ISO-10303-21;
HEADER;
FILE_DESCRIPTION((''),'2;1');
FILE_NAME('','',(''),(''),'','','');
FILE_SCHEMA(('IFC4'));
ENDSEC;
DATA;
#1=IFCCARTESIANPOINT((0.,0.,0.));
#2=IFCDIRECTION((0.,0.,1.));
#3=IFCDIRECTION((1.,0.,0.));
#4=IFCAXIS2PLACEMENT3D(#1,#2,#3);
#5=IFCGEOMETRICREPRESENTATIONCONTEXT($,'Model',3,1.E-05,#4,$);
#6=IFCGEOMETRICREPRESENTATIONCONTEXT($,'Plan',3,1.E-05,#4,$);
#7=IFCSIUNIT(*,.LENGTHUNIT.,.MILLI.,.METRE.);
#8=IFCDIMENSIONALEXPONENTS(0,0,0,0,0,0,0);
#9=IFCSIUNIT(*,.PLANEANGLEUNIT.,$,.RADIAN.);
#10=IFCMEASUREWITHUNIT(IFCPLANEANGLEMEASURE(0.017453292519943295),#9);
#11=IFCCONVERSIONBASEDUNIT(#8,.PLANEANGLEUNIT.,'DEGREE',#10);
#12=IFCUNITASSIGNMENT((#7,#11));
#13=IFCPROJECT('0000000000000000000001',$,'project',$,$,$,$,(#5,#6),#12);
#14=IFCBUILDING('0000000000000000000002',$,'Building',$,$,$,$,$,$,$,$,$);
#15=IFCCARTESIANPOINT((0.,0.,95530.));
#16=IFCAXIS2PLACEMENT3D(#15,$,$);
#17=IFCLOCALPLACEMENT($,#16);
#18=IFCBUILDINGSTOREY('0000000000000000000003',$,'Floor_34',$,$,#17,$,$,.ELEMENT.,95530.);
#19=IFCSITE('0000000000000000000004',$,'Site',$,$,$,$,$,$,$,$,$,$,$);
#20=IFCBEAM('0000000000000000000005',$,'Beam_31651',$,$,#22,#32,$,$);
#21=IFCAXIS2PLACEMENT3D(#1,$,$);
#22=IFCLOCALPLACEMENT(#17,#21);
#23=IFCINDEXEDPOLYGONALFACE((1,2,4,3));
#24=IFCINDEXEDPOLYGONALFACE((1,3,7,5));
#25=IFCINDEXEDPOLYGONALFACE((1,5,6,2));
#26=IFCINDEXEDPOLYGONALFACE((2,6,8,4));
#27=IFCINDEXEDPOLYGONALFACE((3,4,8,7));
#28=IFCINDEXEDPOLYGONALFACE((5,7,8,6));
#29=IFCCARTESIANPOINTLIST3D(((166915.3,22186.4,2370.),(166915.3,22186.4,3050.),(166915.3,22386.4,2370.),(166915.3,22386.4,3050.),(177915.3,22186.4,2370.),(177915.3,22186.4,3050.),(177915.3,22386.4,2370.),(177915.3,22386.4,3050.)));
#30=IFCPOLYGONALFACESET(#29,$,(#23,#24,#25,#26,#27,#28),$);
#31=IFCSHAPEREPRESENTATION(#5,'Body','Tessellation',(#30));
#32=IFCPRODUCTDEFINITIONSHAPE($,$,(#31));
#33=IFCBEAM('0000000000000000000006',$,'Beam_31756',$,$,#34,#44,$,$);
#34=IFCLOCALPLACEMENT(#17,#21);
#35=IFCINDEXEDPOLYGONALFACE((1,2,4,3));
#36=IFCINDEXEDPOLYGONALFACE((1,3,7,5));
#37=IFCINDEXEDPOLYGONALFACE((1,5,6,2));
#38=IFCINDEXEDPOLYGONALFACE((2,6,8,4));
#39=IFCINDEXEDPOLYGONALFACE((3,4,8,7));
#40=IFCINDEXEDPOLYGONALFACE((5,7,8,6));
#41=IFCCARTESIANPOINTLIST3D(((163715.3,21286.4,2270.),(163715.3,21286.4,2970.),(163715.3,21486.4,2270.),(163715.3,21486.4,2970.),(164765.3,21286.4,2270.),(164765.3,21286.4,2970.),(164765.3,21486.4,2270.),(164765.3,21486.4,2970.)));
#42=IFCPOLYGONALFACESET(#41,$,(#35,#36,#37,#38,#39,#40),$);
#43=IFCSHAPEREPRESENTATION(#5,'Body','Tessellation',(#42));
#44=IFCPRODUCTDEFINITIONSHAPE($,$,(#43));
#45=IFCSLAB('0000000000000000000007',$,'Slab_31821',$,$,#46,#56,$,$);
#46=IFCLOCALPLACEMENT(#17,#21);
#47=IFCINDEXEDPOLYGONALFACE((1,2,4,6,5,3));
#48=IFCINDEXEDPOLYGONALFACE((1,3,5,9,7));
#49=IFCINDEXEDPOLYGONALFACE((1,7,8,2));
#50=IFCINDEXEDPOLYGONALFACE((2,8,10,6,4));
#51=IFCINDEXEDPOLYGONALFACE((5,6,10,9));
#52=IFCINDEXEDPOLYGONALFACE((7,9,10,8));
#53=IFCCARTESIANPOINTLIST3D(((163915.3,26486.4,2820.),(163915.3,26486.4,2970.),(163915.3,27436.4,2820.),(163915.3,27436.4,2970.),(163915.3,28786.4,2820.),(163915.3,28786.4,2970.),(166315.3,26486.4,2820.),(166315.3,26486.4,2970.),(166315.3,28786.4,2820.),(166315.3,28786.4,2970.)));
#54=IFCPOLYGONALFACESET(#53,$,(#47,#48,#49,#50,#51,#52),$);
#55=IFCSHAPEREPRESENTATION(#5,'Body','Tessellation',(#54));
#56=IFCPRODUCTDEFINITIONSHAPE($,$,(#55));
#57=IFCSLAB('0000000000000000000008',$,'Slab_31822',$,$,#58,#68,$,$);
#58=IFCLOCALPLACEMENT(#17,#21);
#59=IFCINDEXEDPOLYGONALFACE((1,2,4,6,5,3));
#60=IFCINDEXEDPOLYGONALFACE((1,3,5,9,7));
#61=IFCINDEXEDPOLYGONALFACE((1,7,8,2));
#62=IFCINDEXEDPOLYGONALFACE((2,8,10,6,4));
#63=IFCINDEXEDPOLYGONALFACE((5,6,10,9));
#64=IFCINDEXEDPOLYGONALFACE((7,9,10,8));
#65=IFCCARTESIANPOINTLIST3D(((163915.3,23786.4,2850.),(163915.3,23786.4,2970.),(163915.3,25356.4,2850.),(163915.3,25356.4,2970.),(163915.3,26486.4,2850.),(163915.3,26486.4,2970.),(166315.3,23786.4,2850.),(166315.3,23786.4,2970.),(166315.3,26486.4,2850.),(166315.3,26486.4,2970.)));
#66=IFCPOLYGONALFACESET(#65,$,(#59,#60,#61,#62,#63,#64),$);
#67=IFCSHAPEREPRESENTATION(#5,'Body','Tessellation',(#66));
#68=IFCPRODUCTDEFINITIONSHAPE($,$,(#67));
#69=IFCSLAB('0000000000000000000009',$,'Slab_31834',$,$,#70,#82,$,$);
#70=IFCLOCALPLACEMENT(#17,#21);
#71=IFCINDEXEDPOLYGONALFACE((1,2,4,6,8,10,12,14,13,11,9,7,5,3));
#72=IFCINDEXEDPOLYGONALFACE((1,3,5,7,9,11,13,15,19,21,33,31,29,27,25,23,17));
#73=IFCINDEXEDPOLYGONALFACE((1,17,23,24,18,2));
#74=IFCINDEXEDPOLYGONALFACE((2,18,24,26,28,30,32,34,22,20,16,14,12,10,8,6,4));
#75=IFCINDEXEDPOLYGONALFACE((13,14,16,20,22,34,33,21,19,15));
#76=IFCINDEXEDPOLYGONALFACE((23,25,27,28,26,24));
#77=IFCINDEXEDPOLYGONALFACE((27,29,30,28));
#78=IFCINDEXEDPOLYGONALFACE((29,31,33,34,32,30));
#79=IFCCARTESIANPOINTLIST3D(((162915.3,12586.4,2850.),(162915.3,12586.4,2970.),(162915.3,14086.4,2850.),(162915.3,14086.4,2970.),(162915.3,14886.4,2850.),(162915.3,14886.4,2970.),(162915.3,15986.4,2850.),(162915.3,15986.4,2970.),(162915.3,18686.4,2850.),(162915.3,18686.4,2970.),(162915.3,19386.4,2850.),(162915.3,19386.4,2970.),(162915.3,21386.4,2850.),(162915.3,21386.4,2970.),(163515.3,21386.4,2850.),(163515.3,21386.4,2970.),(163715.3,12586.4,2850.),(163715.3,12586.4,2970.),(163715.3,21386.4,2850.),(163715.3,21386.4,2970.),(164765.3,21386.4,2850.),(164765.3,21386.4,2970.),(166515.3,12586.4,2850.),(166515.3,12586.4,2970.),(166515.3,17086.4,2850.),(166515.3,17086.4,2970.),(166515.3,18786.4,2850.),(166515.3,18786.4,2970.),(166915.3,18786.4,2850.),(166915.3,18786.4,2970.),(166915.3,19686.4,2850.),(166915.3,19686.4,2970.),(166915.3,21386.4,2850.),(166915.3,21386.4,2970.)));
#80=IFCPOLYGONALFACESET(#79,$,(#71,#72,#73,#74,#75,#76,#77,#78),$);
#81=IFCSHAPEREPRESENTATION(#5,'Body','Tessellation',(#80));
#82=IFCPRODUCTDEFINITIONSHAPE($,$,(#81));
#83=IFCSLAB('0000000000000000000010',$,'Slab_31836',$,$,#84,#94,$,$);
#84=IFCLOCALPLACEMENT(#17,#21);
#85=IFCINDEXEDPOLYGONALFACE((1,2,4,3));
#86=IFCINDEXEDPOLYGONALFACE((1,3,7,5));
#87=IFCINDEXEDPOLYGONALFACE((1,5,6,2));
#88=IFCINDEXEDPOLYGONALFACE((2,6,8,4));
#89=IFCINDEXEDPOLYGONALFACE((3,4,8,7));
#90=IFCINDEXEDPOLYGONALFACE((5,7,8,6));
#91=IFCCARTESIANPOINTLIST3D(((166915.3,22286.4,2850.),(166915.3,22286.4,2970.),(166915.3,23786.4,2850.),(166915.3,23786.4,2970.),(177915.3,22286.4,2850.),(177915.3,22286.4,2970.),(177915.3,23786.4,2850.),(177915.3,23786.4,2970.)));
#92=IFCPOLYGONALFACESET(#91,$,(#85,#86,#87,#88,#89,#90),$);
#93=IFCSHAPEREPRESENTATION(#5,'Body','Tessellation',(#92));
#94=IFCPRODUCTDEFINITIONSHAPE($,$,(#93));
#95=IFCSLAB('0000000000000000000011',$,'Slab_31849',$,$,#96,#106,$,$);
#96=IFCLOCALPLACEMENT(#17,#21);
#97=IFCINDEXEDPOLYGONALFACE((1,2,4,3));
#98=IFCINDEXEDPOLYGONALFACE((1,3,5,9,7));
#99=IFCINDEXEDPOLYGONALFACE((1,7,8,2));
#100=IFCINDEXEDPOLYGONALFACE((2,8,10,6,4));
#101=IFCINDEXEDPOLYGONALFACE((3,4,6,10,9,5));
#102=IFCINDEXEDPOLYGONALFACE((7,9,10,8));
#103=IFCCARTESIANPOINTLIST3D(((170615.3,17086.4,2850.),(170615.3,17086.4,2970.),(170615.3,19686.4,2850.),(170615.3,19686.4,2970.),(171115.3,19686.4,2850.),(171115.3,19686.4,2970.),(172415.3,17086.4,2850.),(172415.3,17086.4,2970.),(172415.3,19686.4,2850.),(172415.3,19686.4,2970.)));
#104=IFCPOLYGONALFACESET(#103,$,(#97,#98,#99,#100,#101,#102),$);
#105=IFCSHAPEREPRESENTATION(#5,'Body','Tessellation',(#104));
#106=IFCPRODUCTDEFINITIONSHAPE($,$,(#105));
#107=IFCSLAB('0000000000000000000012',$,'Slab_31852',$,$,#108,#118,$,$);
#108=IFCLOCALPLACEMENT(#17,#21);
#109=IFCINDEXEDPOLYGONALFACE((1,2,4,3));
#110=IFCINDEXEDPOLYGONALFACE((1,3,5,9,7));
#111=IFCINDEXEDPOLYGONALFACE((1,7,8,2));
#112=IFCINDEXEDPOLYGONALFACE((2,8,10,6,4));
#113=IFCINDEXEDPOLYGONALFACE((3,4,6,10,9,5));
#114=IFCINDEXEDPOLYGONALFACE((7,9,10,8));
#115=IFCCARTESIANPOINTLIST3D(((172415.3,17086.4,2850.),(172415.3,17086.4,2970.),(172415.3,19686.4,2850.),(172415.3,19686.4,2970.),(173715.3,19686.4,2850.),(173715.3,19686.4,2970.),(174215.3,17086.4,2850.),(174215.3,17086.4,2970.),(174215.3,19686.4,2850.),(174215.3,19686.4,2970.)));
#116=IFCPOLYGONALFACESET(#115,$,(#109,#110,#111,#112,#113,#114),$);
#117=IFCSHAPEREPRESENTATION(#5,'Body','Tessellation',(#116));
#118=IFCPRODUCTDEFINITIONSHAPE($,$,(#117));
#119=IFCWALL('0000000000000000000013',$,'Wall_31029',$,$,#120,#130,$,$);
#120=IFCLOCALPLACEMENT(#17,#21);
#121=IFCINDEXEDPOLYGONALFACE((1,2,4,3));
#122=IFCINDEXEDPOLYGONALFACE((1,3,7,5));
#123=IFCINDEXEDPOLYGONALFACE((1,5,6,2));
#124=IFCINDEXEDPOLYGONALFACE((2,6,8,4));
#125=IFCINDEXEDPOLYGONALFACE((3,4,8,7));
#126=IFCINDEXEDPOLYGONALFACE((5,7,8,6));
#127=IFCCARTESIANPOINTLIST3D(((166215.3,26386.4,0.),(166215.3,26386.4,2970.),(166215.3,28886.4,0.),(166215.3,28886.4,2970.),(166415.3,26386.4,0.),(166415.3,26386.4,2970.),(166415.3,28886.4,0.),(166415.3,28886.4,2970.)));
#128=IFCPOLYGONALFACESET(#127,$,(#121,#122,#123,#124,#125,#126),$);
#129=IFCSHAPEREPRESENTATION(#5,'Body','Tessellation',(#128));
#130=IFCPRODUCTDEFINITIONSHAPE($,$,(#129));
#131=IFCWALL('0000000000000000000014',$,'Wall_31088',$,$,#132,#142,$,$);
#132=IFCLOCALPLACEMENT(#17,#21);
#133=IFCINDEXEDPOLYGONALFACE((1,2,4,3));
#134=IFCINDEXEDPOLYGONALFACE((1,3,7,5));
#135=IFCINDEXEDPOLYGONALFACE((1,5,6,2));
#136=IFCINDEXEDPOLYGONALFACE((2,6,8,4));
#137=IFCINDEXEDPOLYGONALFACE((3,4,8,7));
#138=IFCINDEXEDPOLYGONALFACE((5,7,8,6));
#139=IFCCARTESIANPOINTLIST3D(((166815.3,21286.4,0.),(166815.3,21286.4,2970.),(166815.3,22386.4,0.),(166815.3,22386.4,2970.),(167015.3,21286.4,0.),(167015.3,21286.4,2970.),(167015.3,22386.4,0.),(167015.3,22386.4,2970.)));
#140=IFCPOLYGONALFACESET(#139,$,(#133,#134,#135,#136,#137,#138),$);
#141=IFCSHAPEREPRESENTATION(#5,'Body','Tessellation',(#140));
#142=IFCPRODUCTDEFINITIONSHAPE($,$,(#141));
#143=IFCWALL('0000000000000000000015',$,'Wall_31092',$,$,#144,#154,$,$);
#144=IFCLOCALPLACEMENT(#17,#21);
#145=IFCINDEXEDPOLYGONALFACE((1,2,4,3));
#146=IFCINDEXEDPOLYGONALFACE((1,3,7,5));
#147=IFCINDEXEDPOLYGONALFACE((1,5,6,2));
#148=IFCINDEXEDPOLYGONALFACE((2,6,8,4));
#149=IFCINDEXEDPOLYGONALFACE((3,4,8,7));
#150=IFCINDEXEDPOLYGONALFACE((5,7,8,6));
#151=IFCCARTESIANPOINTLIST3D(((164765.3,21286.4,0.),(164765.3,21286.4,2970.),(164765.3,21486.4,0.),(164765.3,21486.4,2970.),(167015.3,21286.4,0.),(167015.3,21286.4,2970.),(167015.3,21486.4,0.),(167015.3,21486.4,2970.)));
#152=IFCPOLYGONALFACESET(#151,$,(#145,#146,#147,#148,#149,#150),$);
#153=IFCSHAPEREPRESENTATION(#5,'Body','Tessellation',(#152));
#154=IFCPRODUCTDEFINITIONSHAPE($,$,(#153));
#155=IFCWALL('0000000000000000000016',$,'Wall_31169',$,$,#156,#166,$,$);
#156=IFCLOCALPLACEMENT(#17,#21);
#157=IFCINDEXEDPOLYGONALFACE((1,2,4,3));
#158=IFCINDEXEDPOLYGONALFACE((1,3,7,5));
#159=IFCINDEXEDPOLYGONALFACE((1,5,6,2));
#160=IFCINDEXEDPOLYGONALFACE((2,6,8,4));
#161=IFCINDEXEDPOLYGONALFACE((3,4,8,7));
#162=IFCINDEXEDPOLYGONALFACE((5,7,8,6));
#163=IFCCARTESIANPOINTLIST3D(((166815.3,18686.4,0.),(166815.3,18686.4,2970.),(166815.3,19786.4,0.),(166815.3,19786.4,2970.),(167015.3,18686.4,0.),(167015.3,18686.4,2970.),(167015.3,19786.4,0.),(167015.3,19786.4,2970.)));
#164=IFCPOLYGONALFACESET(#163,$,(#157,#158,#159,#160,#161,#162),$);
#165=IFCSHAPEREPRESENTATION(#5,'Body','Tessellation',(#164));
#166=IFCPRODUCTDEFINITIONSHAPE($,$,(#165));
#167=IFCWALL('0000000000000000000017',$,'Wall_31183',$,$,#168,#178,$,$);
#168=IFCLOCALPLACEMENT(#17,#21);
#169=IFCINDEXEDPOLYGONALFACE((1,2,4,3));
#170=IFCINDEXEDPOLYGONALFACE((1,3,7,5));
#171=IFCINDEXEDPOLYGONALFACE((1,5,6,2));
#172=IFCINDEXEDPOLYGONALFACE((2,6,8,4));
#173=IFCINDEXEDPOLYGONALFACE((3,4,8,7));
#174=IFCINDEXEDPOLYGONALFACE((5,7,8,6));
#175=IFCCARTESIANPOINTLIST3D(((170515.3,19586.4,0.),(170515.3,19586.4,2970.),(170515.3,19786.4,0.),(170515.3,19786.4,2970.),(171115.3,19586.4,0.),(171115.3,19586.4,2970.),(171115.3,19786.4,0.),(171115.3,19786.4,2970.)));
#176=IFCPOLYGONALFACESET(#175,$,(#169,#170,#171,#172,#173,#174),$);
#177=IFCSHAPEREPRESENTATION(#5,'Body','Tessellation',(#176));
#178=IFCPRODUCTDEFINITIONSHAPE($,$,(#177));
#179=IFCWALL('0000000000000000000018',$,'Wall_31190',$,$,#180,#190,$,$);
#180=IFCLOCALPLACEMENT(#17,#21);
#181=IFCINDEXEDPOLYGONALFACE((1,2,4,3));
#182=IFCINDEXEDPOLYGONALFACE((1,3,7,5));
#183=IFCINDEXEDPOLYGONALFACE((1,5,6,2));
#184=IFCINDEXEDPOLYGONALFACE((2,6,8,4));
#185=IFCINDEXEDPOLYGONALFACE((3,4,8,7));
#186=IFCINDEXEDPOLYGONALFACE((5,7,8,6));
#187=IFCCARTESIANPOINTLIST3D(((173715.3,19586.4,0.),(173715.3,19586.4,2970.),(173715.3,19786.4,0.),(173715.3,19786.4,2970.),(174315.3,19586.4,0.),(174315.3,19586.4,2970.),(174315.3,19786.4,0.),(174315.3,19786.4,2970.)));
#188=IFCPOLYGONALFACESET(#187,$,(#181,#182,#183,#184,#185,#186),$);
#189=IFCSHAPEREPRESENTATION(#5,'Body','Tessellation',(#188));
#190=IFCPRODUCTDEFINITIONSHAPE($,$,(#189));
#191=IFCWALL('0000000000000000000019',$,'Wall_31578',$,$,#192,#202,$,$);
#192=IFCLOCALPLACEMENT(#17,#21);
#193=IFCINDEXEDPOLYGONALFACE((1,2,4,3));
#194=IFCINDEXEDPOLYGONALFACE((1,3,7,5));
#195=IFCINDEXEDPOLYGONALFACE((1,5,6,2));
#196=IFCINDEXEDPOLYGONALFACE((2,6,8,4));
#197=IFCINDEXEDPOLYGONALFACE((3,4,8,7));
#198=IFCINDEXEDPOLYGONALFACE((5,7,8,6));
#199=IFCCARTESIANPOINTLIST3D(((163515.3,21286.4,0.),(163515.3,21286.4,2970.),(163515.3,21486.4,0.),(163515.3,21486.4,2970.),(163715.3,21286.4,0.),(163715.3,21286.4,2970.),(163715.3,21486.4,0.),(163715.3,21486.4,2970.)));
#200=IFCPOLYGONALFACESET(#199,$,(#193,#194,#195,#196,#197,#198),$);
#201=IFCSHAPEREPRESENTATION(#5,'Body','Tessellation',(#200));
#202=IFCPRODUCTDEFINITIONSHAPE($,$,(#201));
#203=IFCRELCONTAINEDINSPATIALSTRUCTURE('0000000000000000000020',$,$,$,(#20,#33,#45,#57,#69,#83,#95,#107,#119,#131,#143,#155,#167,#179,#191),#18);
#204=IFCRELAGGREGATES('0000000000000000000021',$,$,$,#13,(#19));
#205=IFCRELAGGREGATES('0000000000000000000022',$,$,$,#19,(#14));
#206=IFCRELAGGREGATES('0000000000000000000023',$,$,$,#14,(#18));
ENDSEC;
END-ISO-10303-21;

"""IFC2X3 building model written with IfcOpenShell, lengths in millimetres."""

from ifc_helpers import new_model, entity, si_unit, converted_unit, frame, origin_with_axes, origin_2d, place, context, project, spatial, polyline, rectangle, outline, extrude, element, save


model = new_model("IFC2X3")

# Units and contexts
model_context = context("Model", 3, precision=1e-05, world=origin_with_axes())
plan_context = context("Plan", 3, precision=1e-05, world=origin_with_axes())
ifc_project = project(units=[si_unit("LENGTHUNIT", "METRE", prefix="MILLI"), converted_unit("PLANEANGLEUNIT", "DEGREE", entity("IfcPlaneAngleMeasure", 0.017453292519943295), si_unit("PLANEANGLEUNIT", "RADIAN"), dimensions=[0, 0, 0, 0, 0, 0, 0])], contexts=[model_context, plan_context])

# Site, building, storey
site = spatial("IfcSite", under=ifc_project, Name="Site")
building = spatial("IfcBuilding", under=site, Name="Building")
storey_placement = place(None, frame((0.0, 0.0, 95530.0)))
storey = spatial("IfcBuildingStorey", under=building, at=storey_placement, Name="Floor_34", CompositionType="ELEMENT", Elevation=95530.0)

# Beams
beam_1_placement = place(storey_placement, frame((166915.3, 22286.4, 2710.0), z_axis=(10999.999785, 0.0, 0.0), x_axis=(0.0, -10999.999785, 0.0)))
element("IfcBeam", 1, at=beam_1_placement, inside=storey, Name="Beam_31651", context=model_context, shape_type="SweptSolid", body=[
    extrude(rectangle(XDim=200.0, YDim=680.0, at=origin_2d()), origin_with_axes(), (0.0, 0.0, 1.0), 11000.0),
])
beam_2_placement = place(storey_placement, frame((163715.3, 21386.4, 2620.0), z_axis=(1050.0, 0.0, 0.0), x_axis=(0.0, -1050.0, 0.0)))
element("IfcBeam", 2, at=beam_2_placement, inside=storey, Name="Beam_31756", context=model_context, shape_type="SweptSolid", body=[
    extrude(rectangle(XDim=200.0, YDim=700.0, at=origin_2d()), origin_with_axes(), (0.0, 0.0, 1.0), 1050.0),
])

# Slabs
slab_1_placement = place(storey_placement, frame((163915.3, 28786.4, 2820.0), z_axis=(0.0, 0.0, 1.0), x_axis=(0.0, -1350.0, 0.0)))
element("IfcSlab", 3, at=slab_1_placement, inside=storey, Name="Slab_31821", context=model_context, shape_type="SweptSolid", body=[
    extrude(outline(polyline([(0.0, 0.0), (1350.0, 0.0), (2300.0, 0.0), (2300.0, 2400.0), (0.0, 2400.0)])), origin_with_axes(), (0.0, 0.0, 1.0), 150.0),
])
slab_2_placement = place(storey_placement, frame((163915.3, 26486.4, 2850.0), z_axis=(0.0, 0.0, 1.0), x_axis=(0.0, -1130.0, 0.0)))
element("IfcSlab", 4, at=slab_2_placement, inside=storey, Name="Slab_31822", context=model_context, shape_type="SweptSolid", body=[
    extrude(outline(polyline([(0.0, 0.0), (1130.0, 0.0), (2700.0, 0.0), (2700.0, 2400.0), (0.0, 2400.0)])), origin_with_axes(), (0.0, 0.0, 1.0), 120.0),
])
slab_3_placement = place(storey_placement, frame((164765.3, 21386.4, 2850.0), z_axis=(0.0, 0.0, 1.0), x_axis=(-1050.0, 0.0, 0.0)))
element("IfcSlab", 5, at=slab_3_placement, inside=storey, Name="Slab_31834", context=model_context, shape_type="SweptSolid", body=[
    extrude(outline(polyline([(0.0, 0.0), (1050.0, 0.0), (1250.0, 0.0), (1850.0, 0.0), (1850.0, 2000.0), (1850.0, 2700.0), (1850.0, 5400.0), (1850.0, 6500.0), (1850.0, 7300.0), (1850.0, 8800.0), (1050.0, 8800.0), (-1750.0, 8800.0), (-1750.0, 4300.0), (-1750.0, 2600.0), (-2150.0, 2600.0), (-2150.0, 1700.0), (-2150.0, 0.0)])), origin_with_axes(), (0.0, 0.0, 1.0), 120.0),
])
slab_4_placement = place(storey_placement, frame((166915.3, 23786.4, 2850.0), z_axis=(0.0, 0.0, 1.0), x_axis=(0.0, -1500.0, 0.0)))
element("IfcSlab", 6, at=slab_4_placement, inside=storey, Name="Slab_31836", context=model_context, shape_type="SweptSolid", body=[
    extrude(outline(polyline([(0.0, 0.0), (1500.0, 0.0), (1500.0, 11000.0), (0.0, 11000.0)])), origin_with_axes(), (0.0, 0.0, 1.0), 120.0),
])
slab_5_placement = place(storey_placement, frame((170615.3, 19686.4, 2850.0), z_axis=(0.0, 0.0, 1.0), x_axis=(0.0, -2599.99, 0.0)))
element("IfcSlab", 7, at=slab_5_placement, inside=storey, Name="Slab_31849", context=model_context, shape_type="SweptSolid", body=[
    extrude(outline(polyline([(0.0, 0.0), (2600.0, 0.0), (2600.0, 1800.0), (0.0, 1800.0), (0.0, 500.0)])), origin_with_axes(), (0.0, 0.0, 1.0), 120.0),
])
slab_6_placement = place(storey_placement, frame((172415.3, 19686.4, 2850.0), z_axis=(0.0, 0.0, 1.0), x_axis=(0.0, -2599.99, 0.0)))
element("IfcSlab", 8, at=slab_6_placement, inside=storey, Name="Slab_31852", context=model_context, shape_type="SweptSolid", body=[
    extrude(outline(polyline([(0.0, 0.0), (2600.0, 0.0), (2600.0, 1800.0), (0.0, 1800.0), (0.0, 1300.0)])), origin_with_axes(), (0.0, 0.0, 1.0), 120.0),
])

# Walls
wall_1_placement = place(storey_placement, frame((166315.3, 27636.4, 0.0), z_axis=(0.0, 0.0, 1.0), x_axis=(0.0, 2500.0, 0.0)))
element("IfcWall", 9, at=wall_1_placement, inside=storey, Name="Wall_31029", context=model_context, shape_type="SweptSolid", body=[
    extrude(rectangle(XDim=2500.0, YDim=200.0, at=origin_2d()), origin_with_axes(), (0.0, 0.0, 1.0), 2970.0),
])
wall_2_placement = place(storey_placement, frame((166915.3, 21836.4, 0.0), z_axis=(0.0, 0.0, 1.0), x_axis=(0.0, 1099.999996, 0.0)))
element("IfcWall", 10, at=wall_2_placement, inside=storey, Name="Wall_31088", context=model_context, shape_type="SweptSolid", body=[
    extrude(rectangle(XDim=1100.0, YDim=200.0, at=origin_2d()), origin_with_axes(), (0.0, 0.0, 1.0), 2970.0),
])
wall_3_placement = place(storey_placement, frame((165890.3, 21386.4, 0.0), z_axis=(0.0, 0.0, 1.0), x_axis=(2250.0, 0.0, 0.0)))
element("IfcWall", 11, at=wall_3_placement, inside=storey, Name="Wall_31092", context=model_context, shape_type="SweptSolid", body=[
    extrude(rectangle(XDim=2250.0, YDim=200.0, at=origin_2d()), origin_with_axes(), (0.0, 0.0, 1.0), 2970.0),
])
wall_4_placement = place(storey_placement, frame((166915.3, 19236.4, 0.0), z_axis=(0.0, 0.0, 1.0), x_axis=(0.0, 1099.990226, 0.0)))
element("IfcWall", 12, at=wall_4_placement, inside=storey, Name="Wall_31169", context=model_context, shape_type="SweptSolid", body=[
    extrude(rectangle(XDim=1100.0, YDim=200.0, at=origin_2d()), origin_with_axes(), (0.0, 0.0, 1.0), 2970.0),
])
for number, where, z_axis, x_axis, name in (
    (13, (170815.3, 19686.4, 0.0), (0.0, 0.0, 1.0), (600.0, 0.0, 0.0), "Wall_31183"),
    (14, (174015.3, 19686.4, 0.0), (0.0, 0.0, 1.0), (600.0, 0.0, 0.0), "Wall_31190"),
):
    element("IfcWall", number, at=place(storey_placement, frame(where, z_axis=z_axis, x_axis=x_axis)), inside=storey, Name=name, context=model_context, shape_type="SweptSolid", body=[
        extrude(rectangle(XDim=600.0, YDim=200.0, at=origin_2d()), origin_with_axes(), (0.0, 0.0, 1.0), 2970.0),
    ])
wall_5_placement = place(storey_placement, frame((163615.3, 21386.4, 0.0), z_axis=(0.0, 0.0, 1.0), x_axis=(200.0, 0.0, 0.0)))
element("IfcWall", 15, at=wall_5_placement, inside=storey, Name="Wall_31578", context=model_context, shape_type="SweptSolid", body=[
    extrude(rectangle(XDim=200.0, YDim=200.0, at=origin_2d()), origin_with_axes(), (0.0, 0.0, 1.0), 2970.0),
])

save(model, "model.ifc")
